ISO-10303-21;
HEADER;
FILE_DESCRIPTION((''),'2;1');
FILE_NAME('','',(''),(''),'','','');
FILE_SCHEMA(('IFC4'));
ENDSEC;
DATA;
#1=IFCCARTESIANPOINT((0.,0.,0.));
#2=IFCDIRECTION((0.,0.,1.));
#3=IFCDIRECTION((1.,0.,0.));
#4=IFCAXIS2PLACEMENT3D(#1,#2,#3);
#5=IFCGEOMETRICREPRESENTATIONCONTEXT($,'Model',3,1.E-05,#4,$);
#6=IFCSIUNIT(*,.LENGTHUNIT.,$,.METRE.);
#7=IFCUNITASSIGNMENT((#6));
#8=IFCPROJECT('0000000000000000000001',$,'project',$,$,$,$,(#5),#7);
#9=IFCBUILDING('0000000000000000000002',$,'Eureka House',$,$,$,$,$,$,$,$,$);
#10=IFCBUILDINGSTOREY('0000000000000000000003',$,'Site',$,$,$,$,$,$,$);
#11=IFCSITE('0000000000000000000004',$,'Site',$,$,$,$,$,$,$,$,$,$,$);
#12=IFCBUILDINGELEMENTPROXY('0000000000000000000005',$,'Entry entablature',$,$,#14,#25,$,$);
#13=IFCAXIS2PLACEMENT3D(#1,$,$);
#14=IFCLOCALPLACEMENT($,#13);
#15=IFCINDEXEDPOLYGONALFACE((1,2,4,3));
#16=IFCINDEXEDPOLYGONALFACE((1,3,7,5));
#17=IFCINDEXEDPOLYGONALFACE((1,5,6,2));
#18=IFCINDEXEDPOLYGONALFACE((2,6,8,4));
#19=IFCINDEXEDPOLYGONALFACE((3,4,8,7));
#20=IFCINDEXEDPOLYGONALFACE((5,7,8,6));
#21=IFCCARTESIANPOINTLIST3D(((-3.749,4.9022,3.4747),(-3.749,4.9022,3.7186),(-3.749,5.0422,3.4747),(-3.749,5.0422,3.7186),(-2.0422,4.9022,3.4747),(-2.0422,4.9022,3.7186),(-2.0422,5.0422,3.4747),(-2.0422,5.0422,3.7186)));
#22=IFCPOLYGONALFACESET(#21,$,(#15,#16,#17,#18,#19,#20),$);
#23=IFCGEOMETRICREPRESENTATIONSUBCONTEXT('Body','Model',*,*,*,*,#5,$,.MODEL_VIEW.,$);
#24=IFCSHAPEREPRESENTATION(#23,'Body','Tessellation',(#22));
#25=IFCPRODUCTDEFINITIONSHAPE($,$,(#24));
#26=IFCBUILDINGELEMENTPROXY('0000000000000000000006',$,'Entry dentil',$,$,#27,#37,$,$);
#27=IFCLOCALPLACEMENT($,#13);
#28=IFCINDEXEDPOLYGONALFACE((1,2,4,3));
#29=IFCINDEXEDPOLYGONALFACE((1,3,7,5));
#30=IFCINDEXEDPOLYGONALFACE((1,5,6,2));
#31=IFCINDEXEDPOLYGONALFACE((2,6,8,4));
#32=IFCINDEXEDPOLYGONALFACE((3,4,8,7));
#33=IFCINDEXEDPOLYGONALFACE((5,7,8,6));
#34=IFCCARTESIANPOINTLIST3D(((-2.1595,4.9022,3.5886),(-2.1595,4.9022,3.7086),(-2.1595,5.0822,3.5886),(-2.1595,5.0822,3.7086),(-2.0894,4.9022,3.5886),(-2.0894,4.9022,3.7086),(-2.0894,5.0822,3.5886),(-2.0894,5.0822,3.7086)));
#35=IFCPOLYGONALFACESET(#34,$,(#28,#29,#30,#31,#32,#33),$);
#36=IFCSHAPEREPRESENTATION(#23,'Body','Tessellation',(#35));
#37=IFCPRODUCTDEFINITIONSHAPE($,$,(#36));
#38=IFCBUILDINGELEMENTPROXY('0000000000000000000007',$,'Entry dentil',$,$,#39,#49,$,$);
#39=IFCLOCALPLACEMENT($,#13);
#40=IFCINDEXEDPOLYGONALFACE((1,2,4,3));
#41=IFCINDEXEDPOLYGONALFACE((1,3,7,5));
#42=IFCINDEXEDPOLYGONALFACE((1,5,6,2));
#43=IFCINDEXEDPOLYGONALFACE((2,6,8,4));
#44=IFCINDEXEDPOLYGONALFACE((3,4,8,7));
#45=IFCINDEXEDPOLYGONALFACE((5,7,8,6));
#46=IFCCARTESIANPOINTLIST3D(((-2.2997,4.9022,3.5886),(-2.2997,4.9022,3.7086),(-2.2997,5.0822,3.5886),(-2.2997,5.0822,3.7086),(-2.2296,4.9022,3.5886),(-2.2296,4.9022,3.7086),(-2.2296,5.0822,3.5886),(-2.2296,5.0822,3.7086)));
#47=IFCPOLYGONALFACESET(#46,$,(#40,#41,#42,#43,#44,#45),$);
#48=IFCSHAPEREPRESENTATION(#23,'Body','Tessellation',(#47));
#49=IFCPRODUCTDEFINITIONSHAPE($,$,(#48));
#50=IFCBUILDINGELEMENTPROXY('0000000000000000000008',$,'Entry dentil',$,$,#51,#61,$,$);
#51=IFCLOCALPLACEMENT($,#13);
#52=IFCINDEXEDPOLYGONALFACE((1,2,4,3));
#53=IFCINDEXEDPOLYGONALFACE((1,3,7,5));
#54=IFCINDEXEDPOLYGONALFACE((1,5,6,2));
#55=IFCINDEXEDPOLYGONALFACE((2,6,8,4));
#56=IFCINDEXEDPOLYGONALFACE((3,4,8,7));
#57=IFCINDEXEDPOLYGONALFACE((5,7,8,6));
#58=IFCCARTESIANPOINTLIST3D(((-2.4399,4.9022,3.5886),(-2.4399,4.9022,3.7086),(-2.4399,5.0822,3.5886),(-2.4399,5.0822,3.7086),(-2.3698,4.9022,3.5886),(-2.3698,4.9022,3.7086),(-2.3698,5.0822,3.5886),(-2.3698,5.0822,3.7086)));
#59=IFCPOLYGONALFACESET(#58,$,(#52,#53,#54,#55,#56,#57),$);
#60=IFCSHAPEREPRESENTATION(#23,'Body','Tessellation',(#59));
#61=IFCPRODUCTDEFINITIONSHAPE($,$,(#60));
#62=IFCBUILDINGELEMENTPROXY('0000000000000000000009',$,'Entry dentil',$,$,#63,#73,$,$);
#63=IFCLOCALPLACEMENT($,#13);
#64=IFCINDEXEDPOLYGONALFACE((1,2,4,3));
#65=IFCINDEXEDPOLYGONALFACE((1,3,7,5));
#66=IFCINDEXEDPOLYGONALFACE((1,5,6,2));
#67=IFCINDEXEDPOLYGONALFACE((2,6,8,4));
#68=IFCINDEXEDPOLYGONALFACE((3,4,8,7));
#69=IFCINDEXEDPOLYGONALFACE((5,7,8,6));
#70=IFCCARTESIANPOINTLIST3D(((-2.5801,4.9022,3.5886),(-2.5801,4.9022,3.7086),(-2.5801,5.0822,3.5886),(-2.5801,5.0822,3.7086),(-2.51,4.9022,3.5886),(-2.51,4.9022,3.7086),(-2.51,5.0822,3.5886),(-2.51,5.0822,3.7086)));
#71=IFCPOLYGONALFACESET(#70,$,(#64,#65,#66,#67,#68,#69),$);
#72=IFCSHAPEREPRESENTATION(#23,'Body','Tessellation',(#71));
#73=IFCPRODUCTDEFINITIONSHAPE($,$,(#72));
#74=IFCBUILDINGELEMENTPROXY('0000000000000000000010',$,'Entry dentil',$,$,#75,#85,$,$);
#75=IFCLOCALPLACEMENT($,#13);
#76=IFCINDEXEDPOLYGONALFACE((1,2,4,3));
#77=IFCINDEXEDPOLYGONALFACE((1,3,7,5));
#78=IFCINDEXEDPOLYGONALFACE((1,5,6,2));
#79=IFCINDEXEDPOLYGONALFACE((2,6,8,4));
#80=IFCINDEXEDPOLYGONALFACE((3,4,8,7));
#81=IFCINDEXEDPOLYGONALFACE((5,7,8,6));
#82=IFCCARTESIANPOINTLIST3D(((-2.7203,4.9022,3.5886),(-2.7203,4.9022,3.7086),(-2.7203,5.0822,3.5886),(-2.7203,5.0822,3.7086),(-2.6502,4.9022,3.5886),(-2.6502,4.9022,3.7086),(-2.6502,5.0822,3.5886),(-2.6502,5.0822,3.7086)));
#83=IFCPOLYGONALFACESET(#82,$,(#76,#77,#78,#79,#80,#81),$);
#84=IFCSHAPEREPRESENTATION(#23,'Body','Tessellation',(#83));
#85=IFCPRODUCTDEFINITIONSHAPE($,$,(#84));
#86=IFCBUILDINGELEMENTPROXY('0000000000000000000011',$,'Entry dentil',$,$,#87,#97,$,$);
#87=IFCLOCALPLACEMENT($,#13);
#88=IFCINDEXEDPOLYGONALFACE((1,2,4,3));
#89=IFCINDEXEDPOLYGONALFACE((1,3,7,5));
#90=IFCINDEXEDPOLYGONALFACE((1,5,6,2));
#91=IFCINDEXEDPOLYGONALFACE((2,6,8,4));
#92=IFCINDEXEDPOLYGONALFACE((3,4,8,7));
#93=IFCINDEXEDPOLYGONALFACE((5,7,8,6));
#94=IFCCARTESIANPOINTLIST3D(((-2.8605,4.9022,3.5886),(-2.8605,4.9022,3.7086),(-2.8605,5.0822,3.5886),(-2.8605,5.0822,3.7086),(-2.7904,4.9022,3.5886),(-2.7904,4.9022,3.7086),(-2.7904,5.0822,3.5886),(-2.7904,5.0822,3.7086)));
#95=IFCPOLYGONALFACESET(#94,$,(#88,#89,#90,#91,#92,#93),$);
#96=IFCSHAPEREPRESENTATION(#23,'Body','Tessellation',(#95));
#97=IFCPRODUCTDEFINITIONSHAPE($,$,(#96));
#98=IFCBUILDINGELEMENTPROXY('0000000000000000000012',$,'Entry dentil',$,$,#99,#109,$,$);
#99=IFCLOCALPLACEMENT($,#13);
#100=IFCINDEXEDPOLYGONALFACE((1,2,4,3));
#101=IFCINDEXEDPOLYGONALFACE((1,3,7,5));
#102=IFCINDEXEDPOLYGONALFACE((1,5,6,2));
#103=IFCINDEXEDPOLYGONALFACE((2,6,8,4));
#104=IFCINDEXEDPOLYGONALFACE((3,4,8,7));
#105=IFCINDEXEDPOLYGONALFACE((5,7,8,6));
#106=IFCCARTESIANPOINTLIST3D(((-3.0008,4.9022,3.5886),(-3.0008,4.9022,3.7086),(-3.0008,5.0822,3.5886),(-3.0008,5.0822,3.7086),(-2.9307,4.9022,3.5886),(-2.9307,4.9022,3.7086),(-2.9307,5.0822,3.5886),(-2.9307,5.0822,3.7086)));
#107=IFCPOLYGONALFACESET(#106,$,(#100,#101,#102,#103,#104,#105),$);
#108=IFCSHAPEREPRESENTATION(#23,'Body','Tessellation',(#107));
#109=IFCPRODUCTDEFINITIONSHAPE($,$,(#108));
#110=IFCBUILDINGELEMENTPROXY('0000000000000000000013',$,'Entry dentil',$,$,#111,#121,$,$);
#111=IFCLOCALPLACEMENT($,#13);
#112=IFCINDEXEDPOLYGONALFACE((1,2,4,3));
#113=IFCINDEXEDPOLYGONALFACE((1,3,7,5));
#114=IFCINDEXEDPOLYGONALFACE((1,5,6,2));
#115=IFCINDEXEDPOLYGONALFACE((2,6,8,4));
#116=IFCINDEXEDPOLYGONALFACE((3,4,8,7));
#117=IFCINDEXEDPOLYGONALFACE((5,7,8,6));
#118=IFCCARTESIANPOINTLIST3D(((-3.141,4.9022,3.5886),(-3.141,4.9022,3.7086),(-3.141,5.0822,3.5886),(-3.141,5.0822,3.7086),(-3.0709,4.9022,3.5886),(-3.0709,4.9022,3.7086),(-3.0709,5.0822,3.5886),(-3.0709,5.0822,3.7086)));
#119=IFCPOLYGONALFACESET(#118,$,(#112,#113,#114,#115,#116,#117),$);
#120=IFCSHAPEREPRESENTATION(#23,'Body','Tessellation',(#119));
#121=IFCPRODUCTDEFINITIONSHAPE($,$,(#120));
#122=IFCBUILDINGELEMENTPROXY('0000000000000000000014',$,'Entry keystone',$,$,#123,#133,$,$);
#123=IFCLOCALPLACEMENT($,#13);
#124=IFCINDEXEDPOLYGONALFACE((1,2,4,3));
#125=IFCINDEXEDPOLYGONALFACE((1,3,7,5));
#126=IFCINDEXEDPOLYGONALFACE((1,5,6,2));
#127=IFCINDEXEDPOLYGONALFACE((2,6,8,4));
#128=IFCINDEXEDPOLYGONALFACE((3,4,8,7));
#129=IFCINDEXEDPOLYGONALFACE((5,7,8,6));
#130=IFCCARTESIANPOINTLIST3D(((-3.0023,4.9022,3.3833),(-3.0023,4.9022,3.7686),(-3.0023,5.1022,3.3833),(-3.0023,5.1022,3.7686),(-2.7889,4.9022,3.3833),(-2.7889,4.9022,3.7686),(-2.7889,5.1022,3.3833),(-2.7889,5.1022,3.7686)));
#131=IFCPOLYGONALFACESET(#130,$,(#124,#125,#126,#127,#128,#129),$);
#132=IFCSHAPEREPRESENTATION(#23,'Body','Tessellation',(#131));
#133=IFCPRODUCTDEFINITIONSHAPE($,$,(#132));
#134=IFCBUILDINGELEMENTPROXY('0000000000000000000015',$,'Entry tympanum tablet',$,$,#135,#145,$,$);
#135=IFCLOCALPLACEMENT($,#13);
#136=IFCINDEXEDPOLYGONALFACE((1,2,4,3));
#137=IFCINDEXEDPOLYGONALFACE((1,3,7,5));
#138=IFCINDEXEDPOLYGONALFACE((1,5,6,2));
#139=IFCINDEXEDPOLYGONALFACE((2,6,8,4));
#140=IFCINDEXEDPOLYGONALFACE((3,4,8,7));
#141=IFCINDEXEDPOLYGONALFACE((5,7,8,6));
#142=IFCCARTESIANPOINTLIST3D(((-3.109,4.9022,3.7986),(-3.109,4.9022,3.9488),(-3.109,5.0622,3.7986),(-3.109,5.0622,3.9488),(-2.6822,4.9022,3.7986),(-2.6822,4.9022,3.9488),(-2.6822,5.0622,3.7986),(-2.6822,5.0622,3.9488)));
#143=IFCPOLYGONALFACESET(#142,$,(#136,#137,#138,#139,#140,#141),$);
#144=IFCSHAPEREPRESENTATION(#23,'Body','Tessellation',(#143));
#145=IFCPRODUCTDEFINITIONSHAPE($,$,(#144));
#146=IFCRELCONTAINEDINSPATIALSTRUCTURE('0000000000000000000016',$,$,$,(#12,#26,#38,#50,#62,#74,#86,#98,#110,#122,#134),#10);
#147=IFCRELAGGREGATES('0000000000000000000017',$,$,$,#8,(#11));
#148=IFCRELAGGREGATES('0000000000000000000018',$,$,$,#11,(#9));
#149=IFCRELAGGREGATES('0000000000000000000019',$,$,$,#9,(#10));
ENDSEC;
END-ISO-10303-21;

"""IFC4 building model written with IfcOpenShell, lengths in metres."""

from ifc_helpers import new_model, si_unit, frame, origin, origin_with_axes, origin_2d, place, context, subcontext, project, spatial, rectangle, extrude, element, save


model = new_model("IFC4")

# Units and contexts
model_context = context("Model", 3, precision=1e-05, world=origin_with_axes())
body_context = subcontext(model_context, "Body", "Model", "MODEL_VIEW")
ifc_project = project(units=[si_unit("LENGTHUNIT", "METRE")], contexts=[model_context])

# Site, building, storey
site = spatial("IfcSite", under=ifc_project, Name="Site")
building = spatial("IfcBuilding", under=site, Name="Eureka House")
storey = spatial("IfcBuildingStorey", under=building, Name="Site")

# Building element proxies
proxy_1_placement = place(None, frame((-2.8956, 4.9722, 3.4747), z_axis=(0.0, 0.0, 1.0), x_axis=(1.0, 0.0, 0.0)))
element("IfcBuildingElementProxy", 1, at=proxy_1_placement, inside=storey, Name="Entry entablature", context=body_context, shape_type="SweptSolid", body=[
    extrude(rectangle(XDim=1.7069, YDim=0.14, at=origin_2d()), origin(), (0.0, 0.0, 1.0), 0.2438),
])
for number, where, z_axis, x_axis, name in (
    (2, (-2.1245, 4.9922, 3.5886), (0.0, 0.0, 1.0), (1.0, 0.0, 0.0), "Entry dentil"),
    (3, (-2.2647, 4.9922, 3.5886), (0.0, 0.0, 1.0), (1.0, 0.0, 0.0), "Entry dentil"),
    (4, (-2.4049, 4.9922, 3.5886), (0.0, 0.0, 1.0), (1.0, 0.0, 0.0), "Entry dentil"),
    (5, (-2.5451, 4.9922, 3.5886), (0.0, 0.0, 1.0), (1.0, 0.0, 0.0), "Entry dentil"),
    (6, (-2.6853, 4.9922, 3.5886), (0.0, 0.0, 1.0), (1.0, 0.0, 0.0), "Entry dentil"),
    (7, (-2.8255, 4.9922, 3.5886), (0.0, 0.0, 1.0), (1.0, 0.0, 0.0), "Entry dentil"),
    (8, (-2.9657, 4.9922, 3.5886), (0.0, 0.0, 1.0), (1.0, 0.0, 0.0), "Entry dentil"),
    (9, (-3.1059, 4.9922, 3.5886), (0.0, 0.0, 1.0), (1.0, 0.0, 0.0), "Entry dentil"),
):
    element("IfcBuildingElementProxy", number, at=place(None, frame(where, z_axis=z_axis, x_axis=x_axis)), inside=storey, Name=name, context=body_context, shape_type="SweptSolid", body=[
        extrude(rectangle(XDim=0.0701, YDim=0.18, at=origin_2d()), origin(), (0.0, 0.0, 1.0), 0.12),
    ])
proxy_2_placement = place(None, frame((-2.8956, 5.0022, 3.3833), z_axis=(0.0, 0.0, 1.0), x_axis=(1.0, 0.0, 0.0)))
element("IfcBuildingElementProxy", 10, at=proxy_2_placement, inside=storey, Name="Entry keystone", context=body_context, shape_type="SweptSolid", body=[
    extrude(rectangle(XDim=0.2134, YDim=0.2, at=origin_2d()), origin(), (0.0, 0.0, 1.0), 0.3853),
])
proxy_3_placement = place(None, frame((-2.8956, 4.9822, 3.7986), z_axis=(0.0, 0.0, 1.0), x_axis=(1.0, 0.0, 0.0)))
element("IfcBuildingElementProxy", 11, at=proxy_3_placement, inside=storey, Name="Entry tympanum tablet", context=body_context, shape_type="SweptSolid", body=[
    extrude(rectangle(XDim=0.4267, YDim=0.16, at=origin_2d()), origin(), (0.0, 0.0, 1.0), 0.1502),
])

save(model, "model.ifc")
